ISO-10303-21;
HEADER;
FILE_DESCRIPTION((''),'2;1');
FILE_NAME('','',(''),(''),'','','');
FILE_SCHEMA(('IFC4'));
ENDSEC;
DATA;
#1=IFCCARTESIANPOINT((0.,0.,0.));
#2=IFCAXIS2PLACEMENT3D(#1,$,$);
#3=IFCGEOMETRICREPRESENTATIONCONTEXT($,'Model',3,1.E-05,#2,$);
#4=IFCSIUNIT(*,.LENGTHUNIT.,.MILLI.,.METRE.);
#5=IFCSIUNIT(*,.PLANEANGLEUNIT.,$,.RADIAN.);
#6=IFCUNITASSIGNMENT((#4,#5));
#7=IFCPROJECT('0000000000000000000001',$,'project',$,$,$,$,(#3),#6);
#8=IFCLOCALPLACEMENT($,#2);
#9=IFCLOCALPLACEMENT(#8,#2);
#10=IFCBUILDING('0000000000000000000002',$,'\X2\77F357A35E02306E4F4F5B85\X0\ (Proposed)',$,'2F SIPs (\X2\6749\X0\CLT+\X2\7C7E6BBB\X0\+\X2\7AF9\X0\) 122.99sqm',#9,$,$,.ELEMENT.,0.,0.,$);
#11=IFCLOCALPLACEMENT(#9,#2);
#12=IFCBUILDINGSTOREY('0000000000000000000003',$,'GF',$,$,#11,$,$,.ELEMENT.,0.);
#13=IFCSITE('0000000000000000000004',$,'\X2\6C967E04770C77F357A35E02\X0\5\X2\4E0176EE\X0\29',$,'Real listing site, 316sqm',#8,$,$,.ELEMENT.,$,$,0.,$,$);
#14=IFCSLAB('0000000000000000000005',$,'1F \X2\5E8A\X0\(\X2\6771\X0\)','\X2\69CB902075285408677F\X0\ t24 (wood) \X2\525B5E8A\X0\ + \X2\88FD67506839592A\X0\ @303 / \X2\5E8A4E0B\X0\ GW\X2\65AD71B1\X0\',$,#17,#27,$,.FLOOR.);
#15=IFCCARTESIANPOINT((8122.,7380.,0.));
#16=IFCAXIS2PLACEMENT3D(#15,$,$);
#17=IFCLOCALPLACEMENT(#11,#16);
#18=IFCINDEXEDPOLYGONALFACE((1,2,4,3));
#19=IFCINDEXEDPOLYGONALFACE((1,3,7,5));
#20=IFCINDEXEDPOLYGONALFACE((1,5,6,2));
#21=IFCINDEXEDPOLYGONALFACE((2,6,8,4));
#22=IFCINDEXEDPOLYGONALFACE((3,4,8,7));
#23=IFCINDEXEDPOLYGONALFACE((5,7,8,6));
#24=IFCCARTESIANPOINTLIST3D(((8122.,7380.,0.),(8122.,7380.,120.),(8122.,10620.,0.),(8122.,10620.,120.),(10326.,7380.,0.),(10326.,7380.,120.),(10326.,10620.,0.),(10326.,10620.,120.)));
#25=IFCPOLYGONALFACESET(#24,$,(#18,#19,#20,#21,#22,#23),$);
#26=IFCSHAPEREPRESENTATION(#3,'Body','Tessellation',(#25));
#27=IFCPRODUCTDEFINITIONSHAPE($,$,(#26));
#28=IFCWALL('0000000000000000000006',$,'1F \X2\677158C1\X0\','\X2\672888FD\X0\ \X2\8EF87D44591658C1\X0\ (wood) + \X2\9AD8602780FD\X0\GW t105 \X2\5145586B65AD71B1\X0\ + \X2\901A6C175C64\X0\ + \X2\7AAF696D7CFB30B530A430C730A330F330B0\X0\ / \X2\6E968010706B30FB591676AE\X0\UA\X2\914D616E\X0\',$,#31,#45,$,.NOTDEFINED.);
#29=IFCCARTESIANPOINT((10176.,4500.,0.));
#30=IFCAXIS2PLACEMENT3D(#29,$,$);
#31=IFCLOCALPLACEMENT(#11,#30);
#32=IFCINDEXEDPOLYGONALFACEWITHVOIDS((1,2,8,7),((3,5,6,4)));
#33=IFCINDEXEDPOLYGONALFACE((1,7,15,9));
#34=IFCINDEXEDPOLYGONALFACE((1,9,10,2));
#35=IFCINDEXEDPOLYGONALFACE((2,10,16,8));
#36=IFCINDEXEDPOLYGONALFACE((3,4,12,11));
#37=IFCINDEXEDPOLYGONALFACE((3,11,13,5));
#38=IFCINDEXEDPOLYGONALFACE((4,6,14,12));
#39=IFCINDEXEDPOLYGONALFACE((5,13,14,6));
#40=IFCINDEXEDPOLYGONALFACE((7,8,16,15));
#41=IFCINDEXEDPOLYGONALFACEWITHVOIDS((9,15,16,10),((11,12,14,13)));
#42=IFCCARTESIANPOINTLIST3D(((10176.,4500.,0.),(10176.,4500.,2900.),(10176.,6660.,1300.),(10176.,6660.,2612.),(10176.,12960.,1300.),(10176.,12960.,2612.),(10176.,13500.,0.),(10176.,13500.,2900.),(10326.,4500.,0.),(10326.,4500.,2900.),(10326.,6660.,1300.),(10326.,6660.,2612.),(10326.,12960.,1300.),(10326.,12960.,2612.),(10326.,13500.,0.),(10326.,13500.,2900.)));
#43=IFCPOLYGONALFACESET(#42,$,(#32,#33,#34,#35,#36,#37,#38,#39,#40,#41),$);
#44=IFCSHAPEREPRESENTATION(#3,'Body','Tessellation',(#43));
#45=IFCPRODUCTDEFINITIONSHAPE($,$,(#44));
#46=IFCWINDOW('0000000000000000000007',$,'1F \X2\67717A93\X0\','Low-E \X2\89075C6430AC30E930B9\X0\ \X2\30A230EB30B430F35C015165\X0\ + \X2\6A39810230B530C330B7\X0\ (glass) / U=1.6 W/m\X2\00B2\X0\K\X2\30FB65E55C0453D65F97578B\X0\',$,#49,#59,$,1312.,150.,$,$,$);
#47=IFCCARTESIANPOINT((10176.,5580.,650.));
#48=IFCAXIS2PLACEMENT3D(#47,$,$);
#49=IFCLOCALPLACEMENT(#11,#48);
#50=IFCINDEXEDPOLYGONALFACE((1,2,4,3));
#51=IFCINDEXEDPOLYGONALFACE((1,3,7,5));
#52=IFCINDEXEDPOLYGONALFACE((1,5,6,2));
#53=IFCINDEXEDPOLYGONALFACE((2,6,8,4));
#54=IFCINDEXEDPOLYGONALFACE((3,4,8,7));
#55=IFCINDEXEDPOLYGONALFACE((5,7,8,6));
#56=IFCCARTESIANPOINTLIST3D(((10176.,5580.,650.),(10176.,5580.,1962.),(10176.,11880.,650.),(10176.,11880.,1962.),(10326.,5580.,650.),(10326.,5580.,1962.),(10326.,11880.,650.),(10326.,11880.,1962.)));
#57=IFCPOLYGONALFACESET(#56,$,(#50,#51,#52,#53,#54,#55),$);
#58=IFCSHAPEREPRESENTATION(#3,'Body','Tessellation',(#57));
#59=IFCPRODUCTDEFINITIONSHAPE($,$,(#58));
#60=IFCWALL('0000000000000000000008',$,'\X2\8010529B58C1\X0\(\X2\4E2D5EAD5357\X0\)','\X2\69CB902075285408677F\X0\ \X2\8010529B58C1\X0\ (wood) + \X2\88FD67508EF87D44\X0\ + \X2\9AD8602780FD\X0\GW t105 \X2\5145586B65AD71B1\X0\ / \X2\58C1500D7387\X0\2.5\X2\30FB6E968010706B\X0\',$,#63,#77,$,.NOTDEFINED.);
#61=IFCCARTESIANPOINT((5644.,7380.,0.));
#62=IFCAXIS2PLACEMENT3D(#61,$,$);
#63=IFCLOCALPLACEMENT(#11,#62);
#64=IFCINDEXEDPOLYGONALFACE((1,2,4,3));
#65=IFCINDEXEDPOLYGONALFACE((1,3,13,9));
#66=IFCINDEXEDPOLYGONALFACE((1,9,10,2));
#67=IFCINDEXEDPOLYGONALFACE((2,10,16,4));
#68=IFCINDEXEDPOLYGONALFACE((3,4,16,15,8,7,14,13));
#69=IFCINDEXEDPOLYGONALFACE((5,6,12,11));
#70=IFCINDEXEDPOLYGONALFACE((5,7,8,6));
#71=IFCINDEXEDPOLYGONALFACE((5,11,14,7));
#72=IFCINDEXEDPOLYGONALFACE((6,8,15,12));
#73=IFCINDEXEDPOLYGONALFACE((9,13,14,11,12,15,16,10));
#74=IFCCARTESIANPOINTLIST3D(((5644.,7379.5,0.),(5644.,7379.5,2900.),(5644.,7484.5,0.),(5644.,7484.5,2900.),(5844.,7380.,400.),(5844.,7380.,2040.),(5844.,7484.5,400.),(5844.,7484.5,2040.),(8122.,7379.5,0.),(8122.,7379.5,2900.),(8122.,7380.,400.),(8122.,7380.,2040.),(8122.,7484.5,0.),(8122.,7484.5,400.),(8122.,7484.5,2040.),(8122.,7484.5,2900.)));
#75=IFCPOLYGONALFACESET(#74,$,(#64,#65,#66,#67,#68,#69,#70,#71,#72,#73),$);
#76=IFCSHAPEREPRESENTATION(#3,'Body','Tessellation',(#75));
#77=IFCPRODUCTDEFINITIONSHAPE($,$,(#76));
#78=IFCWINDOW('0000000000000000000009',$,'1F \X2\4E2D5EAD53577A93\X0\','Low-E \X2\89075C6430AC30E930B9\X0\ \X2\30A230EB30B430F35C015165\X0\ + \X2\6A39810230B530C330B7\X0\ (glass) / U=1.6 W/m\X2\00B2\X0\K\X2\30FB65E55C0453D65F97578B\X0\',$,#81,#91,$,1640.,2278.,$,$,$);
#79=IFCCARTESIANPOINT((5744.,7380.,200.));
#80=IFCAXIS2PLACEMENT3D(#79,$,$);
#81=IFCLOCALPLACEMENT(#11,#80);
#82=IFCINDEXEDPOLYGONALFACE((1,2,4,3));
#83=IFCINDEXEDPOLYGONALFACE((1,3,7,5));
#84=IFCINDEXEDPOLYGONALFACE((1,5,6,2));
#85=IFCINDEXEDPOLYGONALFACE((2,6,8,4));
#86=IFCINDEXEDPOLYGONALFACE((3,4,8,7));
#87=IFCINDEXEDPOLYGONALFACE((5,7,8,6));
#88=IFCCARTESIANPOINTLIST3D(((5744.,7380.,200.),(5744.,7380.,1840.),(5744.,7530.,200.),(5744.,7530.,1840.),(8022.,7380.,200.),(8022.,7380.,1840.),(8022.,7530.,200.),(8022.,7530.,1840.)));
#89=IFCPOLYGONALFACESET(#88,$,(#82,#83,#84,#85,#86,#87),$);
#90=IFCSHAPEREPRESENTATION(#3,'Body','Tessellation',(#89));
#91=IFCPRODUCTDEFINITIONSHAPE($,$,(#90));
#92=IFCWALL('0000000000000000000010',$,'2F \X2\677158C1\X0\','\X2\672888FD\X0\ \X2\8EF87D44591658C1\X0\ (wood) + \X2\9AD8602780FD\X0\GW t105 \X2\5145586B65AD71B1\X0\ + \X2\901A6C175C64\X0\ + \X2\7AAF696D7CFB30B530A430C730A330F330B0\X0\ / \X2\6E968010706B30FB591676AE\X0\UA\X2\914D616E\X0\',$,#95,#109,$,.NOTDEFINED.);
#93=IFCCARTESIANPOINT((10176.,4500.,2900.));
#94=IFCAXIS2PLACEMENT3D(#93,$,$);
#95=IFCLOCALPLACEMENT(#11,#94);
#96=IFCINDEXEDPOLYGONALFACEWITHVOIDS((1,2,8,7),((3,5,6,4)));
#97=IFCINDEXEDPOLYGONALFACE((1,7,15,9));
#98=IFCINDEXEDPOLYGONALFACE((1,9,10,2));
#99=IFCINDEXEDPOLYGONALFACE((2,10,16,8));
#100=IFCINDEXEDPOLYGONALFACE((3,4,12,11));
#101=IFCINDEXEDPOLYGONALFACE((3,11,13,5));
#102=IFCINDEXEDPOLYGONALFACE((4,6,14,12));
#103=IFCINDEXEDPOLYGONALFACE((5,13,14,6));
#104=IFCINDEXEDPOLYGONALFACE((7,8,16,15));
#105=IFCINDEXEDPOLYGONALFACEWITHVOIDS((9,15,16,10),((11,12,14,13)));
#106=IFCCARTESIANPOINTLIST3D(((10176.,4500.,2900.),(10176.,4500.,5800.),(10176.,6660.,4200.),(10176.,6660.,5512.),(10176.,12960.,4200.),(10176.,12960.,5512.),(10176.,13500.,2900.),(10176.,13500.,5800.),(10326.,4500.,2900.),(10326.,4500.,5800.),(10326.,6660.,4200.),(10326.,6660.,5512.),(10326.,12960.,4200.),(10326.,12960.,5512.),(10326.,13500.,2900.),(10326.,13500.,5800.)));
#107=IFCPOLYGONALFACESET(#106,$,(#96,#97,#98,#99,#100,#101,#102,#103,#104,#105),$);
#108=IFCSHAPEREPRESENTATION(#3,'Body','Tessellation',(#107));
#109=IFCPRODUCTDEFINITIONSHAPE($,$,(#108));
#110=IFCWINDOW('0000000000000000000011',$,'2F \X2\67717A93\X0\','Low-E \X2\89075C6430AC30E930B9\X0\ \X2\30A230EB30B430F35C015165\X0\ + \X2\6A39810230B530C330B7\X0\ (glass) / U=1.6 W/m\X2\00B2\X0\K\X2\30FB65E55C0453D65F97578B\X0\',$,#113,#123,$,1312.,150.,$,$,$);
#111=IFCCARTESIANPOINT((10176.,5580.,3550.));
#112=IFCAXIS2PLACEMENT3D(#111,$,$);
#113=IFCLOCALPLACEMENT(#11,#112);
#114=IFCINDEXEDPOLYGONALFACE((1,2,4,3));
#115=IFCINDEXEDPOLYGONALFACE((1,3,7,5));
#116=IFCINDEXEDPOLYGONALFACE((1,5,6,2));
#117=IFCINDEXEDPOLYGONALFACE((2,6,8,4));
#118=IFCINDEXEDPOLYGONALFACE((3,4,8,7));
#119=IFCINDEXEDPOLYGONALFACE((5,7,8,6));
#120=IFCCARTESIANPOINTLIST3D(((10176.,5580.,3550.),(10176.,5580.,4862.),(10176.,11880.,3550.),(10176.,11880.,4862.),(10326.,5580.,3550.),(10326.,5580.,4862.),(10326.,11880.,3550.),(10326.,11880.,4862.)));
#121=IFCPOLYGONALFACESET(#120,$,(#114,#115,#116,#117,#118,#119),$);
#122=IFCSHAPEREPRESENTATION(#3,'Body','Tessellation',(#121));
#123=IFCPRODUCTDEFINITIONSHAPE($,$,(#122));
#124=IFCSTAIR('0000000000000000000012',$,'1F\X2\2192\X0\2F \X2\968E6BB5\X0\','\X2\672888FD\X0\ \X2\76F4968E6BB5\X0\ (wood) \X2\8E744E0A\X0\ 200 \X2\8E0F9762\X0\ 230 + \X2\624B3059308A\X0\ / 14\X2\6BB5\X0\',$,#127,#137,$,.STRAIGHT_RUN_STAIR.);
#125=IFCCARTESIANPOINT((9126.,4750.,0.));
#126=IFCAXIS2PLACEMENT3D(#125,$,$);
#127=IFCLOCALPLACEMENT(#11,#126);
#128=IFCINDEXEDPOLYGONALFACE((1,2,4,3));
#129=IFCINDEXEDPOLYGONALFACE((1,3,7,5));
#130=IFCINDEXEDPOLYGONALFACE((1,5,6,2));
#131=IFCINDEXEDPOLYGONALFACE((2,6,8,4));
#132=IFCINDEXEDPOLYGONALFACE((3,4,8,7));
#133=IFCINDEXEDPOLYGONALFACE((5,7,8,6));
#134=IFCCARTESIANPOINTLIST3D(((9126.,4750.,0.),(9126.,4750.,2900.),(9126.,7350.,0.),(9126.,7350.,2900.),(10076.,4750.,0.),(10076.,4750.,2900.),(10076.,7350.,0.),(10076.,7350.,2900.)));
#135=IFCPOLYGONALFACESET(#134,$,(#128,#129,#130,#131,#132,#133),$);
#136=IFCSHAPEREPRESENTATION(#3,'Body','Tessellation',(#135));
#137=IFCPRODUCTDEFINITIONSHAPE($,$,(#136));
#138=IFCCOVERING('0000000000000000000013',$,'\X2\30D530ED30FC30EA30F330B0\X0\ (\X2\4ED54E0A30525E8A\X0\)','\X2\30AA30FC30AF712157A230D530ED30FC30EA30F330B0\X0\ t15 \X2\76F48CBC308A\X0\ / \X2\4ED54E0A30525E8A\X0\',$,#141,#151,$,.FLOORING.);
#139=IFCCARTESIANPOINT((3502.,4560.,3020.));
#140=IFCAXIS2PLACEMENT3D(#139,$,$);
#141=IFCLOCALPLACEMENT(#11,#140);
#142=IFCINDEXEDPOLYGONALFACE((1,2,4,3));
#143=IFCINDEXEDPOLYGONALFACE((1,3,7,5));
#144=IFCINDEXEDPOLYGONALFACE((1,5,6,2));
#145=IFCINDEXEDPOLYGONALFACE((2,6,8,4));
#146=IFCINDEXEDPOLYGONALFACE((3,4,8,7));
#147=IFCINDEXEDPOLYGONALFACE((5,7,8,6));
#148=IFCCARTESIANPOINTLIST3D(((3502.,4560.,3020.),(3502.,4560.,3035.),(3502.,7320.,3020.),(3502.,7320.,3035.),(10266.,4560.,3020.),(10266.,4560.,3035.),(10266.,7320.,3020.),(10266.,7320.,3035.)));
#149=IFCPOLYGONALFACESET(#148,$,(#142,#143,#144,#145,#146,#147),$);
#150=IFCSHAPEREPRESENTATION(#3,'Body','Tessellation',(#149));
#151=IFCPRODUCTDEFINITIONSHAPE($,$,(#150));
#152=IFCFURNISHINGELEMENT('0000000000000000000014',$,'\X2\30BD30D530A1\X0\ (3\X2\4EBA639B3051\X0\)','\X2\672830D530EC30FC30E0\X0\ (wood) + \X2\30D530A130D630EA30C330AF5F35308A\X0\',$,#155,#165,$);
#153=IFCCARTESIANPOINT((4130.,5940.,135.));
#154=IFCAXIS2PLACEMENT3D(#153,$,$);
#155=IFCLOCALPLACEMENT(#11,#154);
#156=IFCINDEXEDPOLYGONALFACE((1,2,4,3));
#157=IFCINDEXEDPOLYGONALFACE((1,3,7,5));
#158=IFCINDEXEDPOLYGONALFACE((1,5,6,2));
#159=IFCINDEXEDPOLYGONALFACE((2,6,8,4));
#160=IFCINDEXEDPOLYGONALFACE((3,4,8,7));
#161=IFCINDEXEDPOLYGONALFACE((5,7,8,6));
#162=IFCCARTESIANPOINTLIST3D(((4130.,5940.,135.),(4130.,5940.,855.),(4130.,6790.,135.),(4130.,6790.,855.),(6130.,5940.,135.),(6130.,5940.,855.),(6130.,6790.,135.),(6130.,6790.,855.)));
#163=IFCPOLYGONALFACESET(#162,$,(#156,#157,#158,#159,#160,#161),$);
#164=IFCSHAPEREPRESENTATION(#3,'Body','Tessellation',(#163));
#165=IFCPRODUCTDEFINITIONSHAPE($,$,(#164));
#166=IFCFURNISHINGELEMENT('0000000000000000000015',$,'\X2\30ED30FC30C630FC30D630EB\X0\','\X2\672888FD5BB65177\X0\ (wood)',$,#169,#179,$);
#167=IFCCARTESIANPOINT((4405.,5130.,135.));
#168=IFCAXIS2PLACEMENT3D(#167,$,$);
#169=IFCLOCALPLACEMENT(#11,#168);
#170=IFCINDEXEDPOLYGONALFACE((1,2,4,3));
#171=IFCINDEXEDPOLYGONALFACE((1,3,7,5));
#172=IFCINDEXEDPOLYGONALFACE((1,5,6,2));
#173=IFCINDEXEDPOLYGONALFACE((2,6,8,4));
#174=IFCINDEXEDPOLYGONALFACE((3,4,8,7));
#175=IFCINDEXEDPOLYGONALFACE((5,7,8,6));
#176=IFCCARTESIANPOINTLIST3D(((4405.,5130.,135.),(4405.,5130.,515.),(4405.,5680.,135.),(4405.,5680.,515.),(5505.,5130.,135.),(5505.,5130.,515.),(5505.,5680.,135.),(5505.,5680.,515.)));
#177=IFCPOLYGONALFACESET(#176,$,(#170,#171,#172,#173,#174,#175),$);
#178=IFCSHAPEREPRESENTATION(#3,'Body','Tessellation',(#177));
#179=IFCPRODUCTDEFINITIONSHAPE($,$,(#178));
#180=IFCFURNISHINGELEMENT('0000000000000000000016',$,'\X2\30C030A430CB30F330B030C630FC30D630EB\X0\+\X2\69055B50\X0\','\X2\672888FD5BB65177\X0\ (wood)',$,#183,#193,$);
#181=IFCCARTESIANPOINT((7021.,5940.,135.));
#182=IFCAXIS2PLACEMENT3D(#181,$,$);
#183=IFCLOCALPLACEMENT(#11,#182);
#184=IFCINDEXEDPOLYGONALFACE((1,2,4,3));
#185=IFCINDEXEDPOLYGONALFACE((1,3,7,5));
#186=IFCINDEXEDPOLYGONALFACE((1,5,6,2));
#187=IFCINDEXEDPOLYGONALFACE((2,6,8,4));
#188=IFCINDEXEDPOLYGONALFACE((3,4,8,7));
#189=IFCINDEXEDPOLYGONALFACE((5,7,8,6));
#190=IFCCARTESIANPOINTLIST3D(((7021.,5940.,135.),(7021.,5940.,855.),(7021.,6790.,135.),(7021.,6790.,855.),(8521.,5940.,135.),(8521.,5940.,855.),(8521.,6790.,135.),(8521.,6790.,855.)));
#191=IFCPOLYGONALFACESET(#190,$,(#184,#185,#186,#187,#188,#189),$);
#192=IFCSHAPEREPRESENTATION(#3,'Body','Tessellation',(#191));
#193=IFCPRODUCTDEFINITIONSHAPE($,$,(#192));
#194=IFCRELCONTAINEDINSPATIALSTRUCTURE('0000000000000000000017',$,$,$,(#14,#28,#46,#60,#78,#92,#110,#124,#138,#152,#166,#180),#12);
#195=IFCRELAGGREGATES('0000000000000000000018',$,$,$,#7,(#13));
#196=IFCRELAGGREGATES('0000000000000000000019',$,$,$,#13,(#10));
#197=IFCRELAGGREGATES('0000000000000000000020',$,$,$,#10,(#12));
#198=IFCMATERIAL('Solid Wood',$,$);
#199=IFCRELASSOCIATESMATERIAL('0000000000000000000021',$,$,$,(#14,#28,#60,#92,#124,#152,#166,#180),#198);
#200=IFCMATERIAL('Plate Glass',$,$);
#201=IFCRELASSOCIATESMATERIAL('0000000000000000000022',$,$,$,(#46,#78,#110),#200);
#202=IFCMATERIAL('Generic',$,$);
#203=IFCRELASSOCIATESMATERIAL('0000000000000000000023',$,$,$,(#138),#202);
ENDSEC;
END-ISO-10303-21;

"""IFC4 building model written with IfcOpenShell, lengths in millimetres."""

from ifc_helpers import new_model, si_unit, frame, frame_2d, origin, place, context, project, spatial, rectangle, extrude, material, element, fill, save


model = new_model("IFC4")

# Units and contexts
model_context = context("Model", 3, precision=1e-05, world=origin())
ifc_project = project(units=[si_unit("LENGTHUNIT", "METRE", prefix="MILLI"), si_unit("PLANEANGLEUNIT", "RADIAN")], contexts=[model_context])

# Site, building, storey
site_placement = place(None, origin())
site = spatial("IfcSite", under=ifc_project, at=site_placement, Name="沖縄県石垣市5丁目29", ObjectType="Real listing site, 316sqm", CompositionType="ELEMENT", RefElevation=0.0)
building_placement = place(site_placement, origin())
building = spatial("IfcBuilding", under=site, at=building_placement, Name="石垣市の住宅 (Proposed)", ObjectType="2F SIPs (杉CLT+籾殻+竹) 122.99sqm", CompositionType="ELEMENT", ElevationOfRefHeight=0.0, ElevationOfTerrain=0.0)
storey_placement = place(building_placement, origin())
storey = spatial("IfcBuildingStorey", under=building, at=storey_placement, Name="GF", CompositionType="ELEMENT", Elevation=0.0)

# Slab
ifc_material_1 = material(Name="Solid Wood")
slab_placement = place(storey_placement, frame((8122.0, 7380.0, 0.0)))
element("IfcSlab", 1, at=slab_placement, inside=storey, material=ifc_material_1, Name="1F 床(東)", Description="構造用合板 t24 (wood) 剛床 + 製材根太 @303 / 床下 GW断熱", PredefinedType="FLOOR", context=model_context, shape_type="SweptSolid", body=[
    extrude(rectangle(XDim=2204.0, YDim=3240.0, at=frame_2d((1102.0, 1620.0))), frame((8122.0, 7380.0, 0.0)), (0.0, 0.0, 1.0), 120.0),
])

# Walls, openings, windows
wall_1_placement = place(storey_placement, frame((10176.0, 4500.0, 0.0)))
wall_1 = element("IfcWall", 2, at=wall_1_placement, inside=storey, material=ifc_material_1, Name="1F 東壁", Description="木製 軸組外壁 (wood) + 高性能GW t105 充填断熱 + 通気層 + 窯業系サイディング / 準耐火・外皮UA配慮", PredefinedType="NOTDEFINED", context=model_context, shape_type="SweptSolid", body=[
    extrude(rectangle(XDim=150.0, YDim=9000.0, at=frame_2d((75.0, 4500.0))), frame((10176.0, 4500.0, 0.0)), (0.0, 0.0, 1.0), 2900.0),
])
opening_1_placement = place(storey_placement, frame((10176.0, 5580.0, 650.0)))
opening_1 = element("IfcOpeningElement", 3, at=opening_1_placement, cuts=wall_1, PredefinedType="NOTDEFINED", context=model_context, shape_type="SweptSolid", body=[
    extrude(rectangle(XDim=150.0, YDim=6300.0, at=frame_2d((75.0, 3150.0))), frame((10176.0, 5580.0, 650.0)), (0.0, 0.0, 1.0), 1312.0),
])
ifc_material_2 = material(Name="Plate Glass")
window_1_placement = place(storey_placement, frame((10176.0, 5580.0, 650.0)))
window_1 = element("IfcWindow", 4, at=window_1_placement, inside=storey, material=ifc_material_2, Name="1F 東窓", Description="Low-E 複層ガラス アルゴン封入 + 樹脂サッシ (glass) / U=1.6 W/m²K・日射取得型", OverallHeight=1312.0, OverallWidth=150.0, context=model_context, shape_type="SweptSolid", body=[
    extrude(rectangle(XDim=150.0, YDim=6300.0, at=frame_2d((75.0, 3150.0))), frame((10176.0, 5580.0, 650.0)), (0.0, 0.0, 1.0), 1312.0),
])
fill(opening_1, window_1)
wall_2_placement = place(storey_placement, frame((5644.0, 7380.0, 0.0)))
wall_2 = element("IfcWall", 5, at=wall_2_placement, inside=storey, material=ifc_material_1, Name="耐力壁(中庭南)", Description="構造用合板 耐力壁 (wood) + 製材軸組 + 高性能GW t105 充填断熱 / 壁倍率2.5・準耐火", PredefinedType="NOTDEFINED", context=model_context, shape_type="SweptSolid", body=[
    extrude(rectangle(XDim=2478.0, YDim=105.0, at=frame_2d((1239.0, 52.0))), frame((5644.0, 7380.0, 0.0)), (0.0, 0.0, 1.0), 2900.0),
])
opening_2_placement = place(storey_placement, frame((5744.0, 7380.0, 200.0)))
opening_2 = element("IfcOpeningElement", 6, at=opening_2_placement, cuts=wall_2, PredefinedType="NOTDEFINED", context=model_context, shape_type="SweptSolid", body=[
    extrude(rectangle(XDim=2278.0, YDim=150.0, at=frame_2d((1139.0, 75.0))), frame((5744.0, 7380.0, 200.0)), (0.0, 0.0, 1.0), 1640.0),
])
window_2_placement = place(storey_placement, frame((5744.0, 7380.0, 200.0)))
window_2 = element("IfcWindow", 7, at=window_2_placement, inside=storey, material=ifc_material_2, Name="1F 中庭南窓", Description="Low-E 複層ガラス アルゴン封入 + 樹脂サッシ (glass) / U=1.6 W/m²K・日射取得型", OverallHeight=1640.0, OverallWidth=2278.0, context=model_context, shape_type="SweptSolid", body=[
    extrude(rectangle(XDim=2278.0, YDim=150.0, at=frame_2d((1139.0, 75.0))), frame((5744.0, 7380.0, 200.0)), (0.0, 0.0, 1.0), 1640.0),
])
fill(opening_2, window_2)

# Wall, opening, window
wall_3_placement = place(storey_placement, frame((10176.0, 4500.0, 2900.0)))
wall_3 = element("IfcWall", 8, at=wall_3_placement, inside=storey, material=ifc_material_1, Name="2F 東壁", Description="木製 軸組外壁 (wood) + 高性能GW t105 充填断熱 + 通気層 + 窯業系サイディング / 準耐火・外皮UA配慮", PredefinedType="NOTDEFINED", context=model_context, shape_type="SweptSolid", body=[
    extrude(rectangle(XDim=150.0, YDim=9000.0, at=frame_2d((75.0, 4500.0))), frame((10176.0, 4500.0, 2900.0)), (0.0, 0.0, 1.0), 2900.0),
])
opening_3_placement = place(storey_placement, frame((10176.0, 5580.0, 3550.0)))
opening_3 = element("IfcOpeningElement", 9, at=opening_3_placement, cuts=wall_3, PredefinedType="NOTDEFINED", context=model_context, shape_type="SweptSolid", body=[
    extrude(rectangle(XDim=150.0, YDim=6300.0, at=frame_2d((75.0, 3150.0))), frame((10176.0, 5580.0, 3550.0)), (0.0, 0.0, 1.0), 1312.0),
])
window_3_placement = place(storey_placement, frame((10176.0, 5580.0, 3550.0)))
window_3 = element("IfcWindow", 10, at=window_3_placement, inside=storey, material=ifc_material_2, Name="2F 東窓", Description="Low-E 複層ガラス アルゴン封入 + 樹脂サッシ (glass) / U=1.6 W/m²K・日射取得型", OverallHeight=1312.0, OverallWidth=150.0, context=model_context, shape_type="SweptSolid", body=[
    extrude(rectangle(XDim=150.0, YDim=6300.0, at=frame_2d((75.0, 3150.0))), frame((10176.0, 5580.0, 3550.0)), (0.0, 0.0, 1.0), 1312.0),
])
fill(opening_3, window_3)

# Stair
stair_placement = place(storey_placement, frame((9126.0, 4750.0, 0.0)))
element("IfcStair", 11, at=stair_placement, inside=storey, material=ifc_material_1, Name="1F→2F 階段", Description="木製 直階段 (wood) 蹴上 200 踏面 230 + 手すり / 14段", PredefinedType="STRAIGHT_RUN_STAIR", context=model_context, shape_type="SweptSolid", body=[
    extrude(rectangle(XDim=950.0, YDim=2600.0, at=frame_2d((475.0, 1300.0))), frame((9126.0, 4750.0, 0.0)), (0.0, 0.0, 1.0), 2900.0),
])

# Covering
ifc_material_3 = material(Name="Generic")
covering_placement = place(storey_placement, frame((3502.0, 4560.0, 3020.0)))
element("IfcCovering", 12, at=covering_placement, inside=storey, material=ifc_material_3, Name="フローリング (仕上げ床)", Description="オーク無垢フローリング t15 直貼り / 仕上げ床", PredefinedType="FLOORING", context=model_context, shape_type="SweptSolid", body=[
    extrude(rectangle(XDim=6764.0, YDim=2760.0, at=frame_2d((3382.0, 1380.0))), frame((3502.0, 4560.0, 3020.0)), (0.0, 0.0, 1.0), 15.0),
])

# Furnishing elements
furnishing_1_placement = place(storey_placement, frame((4130.0, 5940.0, 135.0)))
element("IfcFurnishingElement", 13, at=furnishing_1_placement, inside=storey, material=ifc_material_1, Name="ソファ (3人掛け)", Description="木フレーム (wood) + ファブリック張り", context=model_context, shape_type="SweptSolid", body=[
    extrude(rectangle(XDim=2000.0, YDim=850.0, at=frame_2d((1000.0, 425.0))), frame((4130.0, 5940.0, 135.0)), (0.0, 0.0, 1.0), 720.0),
])
furnishing_2_placement = place(storey_placement, frame((4405.0, 5130.0, 135.0)))
element("IfcFurnishingElement", 14, at=furnishing_2_placement, inside=storey, material=ifc_material_1, Name="ローテーブル", Description="木製家具 (wood)", context=model_context, shape_type="SweptSolid", body=[
    extrude(rectangle(XDim=1100.0, YDim=550.0, at=frame_2d((550.0, 275.0))), frame((4405.0, 5130.0, 135.0)), (0.0, 0.0, 1.0), 380.0),
])
furnishing_3_placement = place(storey_placement, frame((7021.0, 5940.0, 135.0)))
element("IfcFurnishingElement", 15, at=furnishing_3_placement, inside=storey, material=ifc_material_1, Name="ダイニングテーブル+椅子", Description="木製家具 (wood)", context=model_context, shape_type="SweptSolid", body=[
    extrude(rectangle(XDim=1500.0, YDim=850.0, at=frame_2d((750.0, 425.0))), frame((7021.0, 5940.0, 135.0)), (0.0, 0.0, 1.0), 720.0),
])

save(model, "model.ifc")
